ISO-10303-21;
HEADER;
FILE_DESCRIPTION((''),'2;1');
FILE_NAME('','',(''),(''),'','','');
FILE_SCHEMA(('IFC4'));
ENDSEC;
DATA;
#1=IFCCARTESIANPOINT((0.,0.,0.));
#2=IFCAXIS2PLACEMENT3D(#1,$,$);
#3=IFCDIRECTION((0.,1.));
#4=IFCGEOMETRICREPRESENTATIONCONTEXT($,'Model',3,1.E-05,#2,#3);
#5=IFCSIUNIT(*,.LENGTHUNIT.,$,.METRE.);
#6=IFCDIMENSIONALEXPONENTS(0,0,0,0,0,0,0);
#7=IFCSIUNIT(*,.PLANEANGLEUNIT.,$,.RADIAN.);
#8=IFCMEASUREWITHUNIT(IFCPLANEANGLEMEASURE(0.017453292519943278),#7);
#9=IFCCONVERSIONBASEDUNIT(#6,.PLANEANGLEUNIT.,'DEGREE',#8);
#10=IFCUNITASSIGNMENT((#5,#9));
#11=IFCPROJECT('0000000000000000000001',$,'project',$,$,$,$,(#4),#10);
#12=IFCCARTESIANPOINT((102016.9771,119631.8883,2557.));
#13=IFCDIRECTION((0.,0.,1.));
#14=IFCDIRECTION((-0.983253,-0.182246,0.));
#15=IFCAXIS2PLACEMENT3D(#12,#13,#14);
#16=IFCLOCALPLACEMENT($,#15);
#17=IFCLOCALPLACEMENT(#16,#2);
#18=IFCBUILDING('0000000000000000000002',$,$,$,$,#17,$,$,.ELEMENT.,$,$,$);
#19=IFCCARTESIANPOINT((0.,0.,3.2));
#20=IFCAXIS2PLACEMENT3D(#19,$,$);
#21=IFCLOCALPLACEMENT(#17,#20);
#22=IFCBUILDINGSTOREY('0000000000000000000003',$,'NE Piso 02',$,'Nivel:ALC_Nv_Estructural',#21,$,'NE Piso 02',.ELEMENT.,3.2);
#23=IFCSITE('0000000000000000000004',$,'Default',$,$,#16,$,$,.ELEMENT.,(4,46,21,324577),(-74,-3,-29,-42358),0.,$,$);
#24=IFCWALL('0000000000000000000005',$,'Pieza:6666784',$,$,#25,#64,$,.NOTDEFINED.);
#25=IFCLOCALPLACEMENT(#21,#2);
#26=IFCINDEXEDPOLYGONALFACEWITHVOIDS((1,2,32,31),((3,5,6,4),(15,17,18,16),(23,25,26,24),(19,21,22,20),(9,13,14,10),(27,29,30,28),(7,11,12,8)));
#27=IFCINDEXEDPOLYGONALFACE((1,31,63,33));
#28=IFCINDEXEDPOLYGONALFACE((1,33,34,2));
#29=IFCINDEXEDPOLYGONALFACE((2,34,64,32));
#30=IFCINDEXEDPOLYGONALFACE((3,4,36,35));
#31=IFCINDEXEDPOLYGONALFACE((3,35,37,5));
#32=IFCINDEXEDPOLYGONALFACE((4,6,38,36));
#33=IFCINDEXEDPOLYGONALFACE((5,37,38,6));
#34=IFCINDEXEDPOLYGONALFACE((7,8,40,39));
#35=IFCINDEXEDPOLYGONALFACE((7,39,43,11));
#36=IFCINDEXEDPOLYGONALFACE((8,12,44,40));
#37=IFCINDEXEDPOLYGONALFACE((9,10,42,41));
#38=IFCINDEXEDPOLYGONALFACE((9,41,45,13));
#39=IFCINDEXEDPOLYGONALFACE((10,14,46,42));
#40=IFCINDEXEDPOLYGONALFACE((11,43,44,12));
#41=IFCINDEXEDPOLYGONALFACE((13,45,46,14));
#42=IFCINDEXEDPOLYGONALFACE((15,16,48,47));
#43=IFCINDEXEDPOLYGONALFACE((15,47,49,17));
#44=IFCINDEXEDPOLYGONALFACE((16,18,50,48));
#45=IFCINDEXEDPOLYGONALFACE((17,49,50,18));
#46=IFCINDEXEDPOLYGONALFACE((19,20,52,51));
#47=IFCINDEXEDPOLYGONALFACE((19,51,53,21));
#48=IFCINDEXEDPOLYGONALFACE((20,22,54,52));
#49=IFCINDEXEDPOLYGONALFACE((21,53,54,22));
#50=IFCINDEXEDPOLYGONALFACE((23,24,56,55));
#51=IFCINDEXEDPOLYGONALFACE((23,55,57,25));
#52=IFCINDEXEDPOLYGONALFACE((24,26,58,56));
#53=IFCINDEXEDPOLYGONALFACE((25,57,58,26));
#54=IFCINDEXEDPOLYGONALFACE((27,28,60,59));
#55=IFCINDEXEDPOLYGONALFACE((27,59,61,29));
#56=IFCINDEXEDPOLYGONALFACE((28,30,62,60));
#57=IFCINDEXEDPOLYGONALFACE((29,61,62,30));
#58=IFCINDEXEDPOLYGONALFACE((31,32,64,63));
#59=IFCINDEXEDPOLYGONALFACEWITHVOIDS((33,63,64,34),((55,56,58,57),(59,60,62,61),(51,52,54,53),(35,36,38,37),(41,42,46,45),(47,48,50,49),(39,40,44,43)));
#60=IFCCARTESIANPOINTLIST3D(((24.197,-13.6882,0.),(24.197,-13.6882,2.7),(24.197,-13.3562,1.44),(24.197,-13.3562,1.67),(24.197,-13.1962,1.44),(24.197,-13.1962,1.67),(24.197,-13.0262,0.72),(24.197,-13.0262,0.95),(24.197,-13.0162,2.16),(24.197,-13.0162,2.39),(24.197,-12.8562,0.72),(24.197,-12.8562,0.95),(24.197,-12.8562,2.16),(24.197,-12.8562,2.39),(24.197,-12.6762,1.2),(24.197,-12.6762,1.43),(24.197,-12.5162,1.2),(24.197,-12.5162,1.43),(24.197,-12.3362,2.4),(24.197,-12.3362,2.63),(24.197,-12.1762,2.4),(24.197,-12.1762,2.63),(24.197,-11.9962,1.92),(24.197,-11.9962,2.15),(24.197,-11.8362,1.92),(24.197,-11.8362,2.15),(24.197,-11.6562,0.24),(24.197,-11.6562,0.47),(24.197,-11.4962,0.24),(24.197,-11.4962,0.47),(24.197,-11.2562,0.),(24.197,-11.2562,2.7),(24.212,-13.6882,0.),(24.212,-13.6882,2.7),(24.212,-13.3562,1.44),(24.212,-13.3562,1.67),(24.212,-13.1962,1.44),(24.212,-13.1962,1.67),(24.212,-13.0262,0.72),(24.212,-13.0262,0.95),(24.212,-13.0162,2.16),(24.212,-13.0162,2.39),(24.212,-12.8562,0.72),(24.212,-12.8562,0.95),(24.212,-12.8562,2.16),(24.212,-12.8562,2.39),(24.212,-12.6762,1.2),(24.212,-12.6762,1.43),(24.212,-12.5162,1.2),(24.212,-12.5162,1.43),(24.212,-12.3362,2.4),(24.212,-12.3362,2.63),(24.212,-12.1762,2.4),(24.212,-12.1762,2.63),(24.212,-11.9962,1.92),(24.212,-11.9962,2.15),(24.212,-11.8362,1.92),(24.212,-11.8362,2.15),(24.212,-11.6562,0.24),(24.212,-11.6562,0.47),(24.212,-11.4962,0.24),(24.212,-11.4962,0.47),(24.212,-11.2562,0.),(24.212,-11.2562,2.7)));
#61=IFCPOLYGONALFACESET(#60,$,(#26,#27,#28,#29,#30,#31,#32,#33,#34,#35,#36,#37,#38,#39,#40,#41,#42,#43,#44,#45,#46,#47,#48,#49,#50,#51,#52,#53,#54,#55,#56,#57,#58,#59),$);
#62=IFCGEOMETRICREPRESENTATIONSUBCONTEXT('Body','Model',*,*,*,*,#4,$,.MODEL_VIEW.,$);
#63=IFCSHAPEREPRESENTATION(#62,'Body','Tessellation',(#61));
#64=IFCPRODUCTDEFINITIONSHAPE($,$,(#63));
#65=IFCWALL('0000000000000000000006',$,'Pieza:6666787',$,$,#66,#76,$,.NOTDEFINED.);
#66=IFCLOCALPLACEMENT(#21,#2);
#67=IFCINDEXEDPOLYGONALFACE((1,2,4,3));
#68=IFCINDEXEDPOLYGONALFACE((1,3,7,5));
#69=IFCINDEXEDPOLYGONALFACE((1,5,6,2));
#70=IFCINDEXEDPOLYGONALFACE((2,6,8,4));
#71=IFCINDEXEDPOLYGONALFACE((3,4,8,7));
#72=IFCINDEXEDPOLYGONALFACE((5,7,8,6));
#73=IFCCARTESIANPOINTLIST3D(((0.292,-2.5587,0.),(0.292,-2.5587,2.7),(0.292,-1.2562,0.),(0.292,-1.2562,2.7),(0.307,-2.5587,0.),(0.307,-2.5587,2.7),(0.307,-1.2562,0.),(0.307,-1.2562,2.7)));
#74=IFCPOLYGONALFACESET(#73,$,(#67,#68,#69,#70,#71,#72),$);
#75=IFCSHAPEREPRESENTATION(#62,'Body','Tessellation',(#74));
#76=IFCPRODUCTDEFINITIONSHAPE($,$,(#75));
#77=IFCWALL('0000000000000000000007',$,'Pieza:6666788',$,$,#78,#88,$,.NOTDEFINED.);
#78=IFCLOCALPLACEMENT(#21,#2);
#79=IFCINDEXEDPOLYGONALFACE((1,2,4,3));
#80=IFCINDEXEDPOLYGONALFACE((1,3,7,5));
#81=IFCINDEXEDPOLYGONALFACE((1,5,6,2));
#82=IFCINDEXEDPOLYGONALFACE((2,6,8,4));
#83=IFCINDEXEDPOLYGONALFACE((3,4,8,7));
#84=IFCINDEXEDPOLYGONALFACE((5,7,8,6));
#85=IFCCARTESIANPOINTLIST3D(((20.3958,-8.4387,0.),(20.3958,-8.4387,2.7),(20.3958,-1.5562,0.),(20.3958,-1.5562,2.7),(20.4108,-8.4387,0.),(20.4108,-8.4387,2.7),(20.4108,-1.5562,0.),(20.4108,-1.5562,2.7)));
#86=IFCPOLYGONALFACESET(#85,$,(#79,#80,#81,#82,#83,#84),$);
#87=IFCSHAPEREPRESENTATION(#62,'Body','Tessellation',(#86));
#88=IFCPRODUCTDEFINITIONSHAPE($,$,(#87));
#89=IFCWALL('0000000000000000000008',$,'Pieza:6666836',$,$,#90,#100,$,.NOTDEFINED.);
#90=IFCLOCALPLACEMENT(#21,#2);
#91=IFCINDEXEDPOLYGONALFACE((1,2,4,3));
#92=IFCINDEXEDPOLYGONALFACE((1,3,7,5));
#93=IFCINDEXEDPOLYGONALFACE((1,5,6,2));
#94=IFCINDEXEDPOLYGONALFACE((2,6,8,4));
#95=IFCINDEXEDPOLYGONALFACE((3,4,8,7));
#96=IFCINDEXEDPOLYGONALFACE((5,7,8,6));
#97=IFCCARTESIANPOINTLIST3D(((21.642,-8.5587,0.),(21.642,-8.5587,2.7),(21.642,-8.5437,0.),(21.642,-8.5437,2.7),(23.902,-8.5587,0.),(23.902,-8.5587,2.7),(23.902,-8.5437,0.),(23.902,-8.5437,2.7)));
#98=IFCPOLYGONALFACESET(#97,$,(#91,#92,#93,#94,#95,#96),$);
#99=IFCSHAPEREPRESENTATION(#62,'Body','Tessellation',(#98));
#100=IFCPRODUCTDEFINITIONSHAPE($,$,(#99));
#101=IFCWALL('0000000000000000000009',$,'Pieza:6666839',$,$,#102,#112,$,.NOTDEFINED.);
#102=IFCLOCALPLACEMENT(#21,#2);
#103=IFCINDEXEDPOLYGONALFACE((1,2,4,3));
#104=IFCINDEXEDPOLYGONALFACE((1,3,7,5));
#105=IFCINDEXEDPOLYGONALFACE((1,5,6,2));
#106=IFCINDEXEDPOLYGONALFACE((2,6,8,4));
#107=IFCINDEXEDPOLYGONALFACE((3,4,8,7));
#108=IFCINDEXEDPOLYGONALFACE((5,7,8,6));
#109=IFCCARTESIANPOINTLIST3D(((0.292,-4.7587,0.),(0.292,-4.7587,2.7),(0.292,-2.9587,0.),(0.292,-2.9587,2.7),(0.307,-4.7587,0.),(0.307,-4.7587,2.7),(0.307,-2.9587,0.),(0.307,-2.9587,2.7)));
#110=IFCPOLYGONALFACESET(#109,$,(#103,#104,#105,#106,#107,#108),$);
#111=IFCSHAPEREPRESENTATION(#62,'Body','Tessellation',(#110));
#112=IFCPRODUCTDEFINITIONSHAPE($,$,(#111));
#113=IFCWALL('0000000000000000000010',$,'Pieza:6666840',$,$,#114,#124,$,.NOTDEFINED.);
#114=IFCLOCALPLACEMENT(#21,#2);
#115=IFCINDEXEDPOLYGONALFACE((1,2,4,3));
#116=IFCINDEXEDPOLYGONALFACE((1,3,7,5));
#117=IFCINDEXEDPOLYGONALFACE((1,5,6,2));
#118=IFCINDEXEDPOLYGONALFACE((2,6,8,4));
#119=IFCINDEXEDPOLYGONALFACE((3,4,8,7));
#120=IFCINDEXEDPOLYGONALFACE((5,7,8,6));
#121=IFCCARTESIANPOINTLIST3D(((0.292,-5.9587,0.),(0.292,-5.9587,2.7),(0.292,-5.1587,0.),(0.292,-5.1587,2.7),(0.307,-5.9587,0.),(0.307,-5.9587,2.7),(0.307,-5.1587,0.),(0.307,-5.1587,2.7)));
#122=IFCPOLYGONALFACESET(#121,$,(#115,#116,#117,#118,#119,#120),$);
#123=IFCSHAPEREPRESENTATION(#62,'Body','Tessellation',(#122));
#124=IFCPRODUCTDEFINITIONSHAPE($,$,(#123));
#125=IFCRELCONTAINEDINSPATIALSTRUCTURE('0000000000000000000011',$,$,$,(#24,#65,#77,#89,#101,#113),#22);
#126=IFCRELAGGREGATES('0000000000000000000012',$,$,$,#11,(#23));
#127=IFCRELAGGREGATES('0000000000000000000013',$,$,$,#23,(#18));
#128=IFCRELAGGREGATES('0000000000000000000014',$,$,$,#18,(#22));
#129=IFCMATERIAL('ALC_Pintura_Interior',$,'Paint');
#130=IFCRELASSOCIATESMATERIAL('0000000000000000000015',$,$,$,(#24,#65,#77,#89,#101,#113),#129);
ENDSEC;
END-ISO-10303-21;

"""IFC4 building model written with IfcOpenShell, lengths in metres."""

from ifc_helpers import new_model, entity, si_unit, converted_unit, direction, frame, frame_2d, origin, place, context, subcontext, project, spatial, rectangle, extrude, boolean, material, element, save


model = new_model("IFC4")

# Units and contexts
model_context = context("Model", 3, precision=1e-05, world=origin(), true_north=direction((0.0, 1.0)))
body_context = subcontext(model_context, "Body", "Model", "MODEL_VIEW")
ifc_project = project(units=[si_unit("LENGTHUNIT", "METRE"), converted_unit("PLANEANGLEUNIT", "DEGREE", entity("IfcPlaneAngleMeasure", 0.017453292519943278), si_unit("PLANEANGLEUNIT", "RADIAN"), dimensions=[0, 0, 0, 0, 0, 0, 0])], contexts=[model_context])

# Site, building, storey
site_placement = place(None, frame((102016.9771, 119631.8883, 2557.0), z_axis=(0.0, 0.0, 1.0), x_axis=(-0.983253, -0.182246, 0.0)))
site = spatial("IfcSite", under=ifc_project, at=site_placement, Name="Default", CompositionType="ELEMENT", RefLatitude=(4, 46, 21, 324577), RefLongitude=(-74, -3, -29, -42358), RefElevation=0.0)
building_placement = place(site_placement, origin())
building = spatial("IfcBuilding", under=site, at=building_placement, CompositionType="ELEMENT")
storey_placement = place(building_placement, frame((0.0, 0.0, 3.2)))
storey = spatial("IfcBuildingStorey", under=building, at=storey_placement, Name="NE Piso 02", ObjectType="Nivel:ALC_Nv_Estructural", LongName="NE Piso 02", CompositionType="ELEMENT", Elevation=3.2)

# Walls
ifc_material_1 = material(Name="ALC_Pintura_Interior", Category="Paint")
wall_1_placement = place(storey_placement, origin())
element("IfcWall", 1, at=wall_1_placement, inside=storey, material=ifc_material_1, Name="Pieza:6666784", PredefinedType="NOTDEFINED", context=body_context, shape_type="SweptSolid", body=[
    boolean("DIFFERENCE", boolean("DIFFERENCE", boolean("DIFFERENCE", boolean("DIFFERENCE", boolean("DIFFERENCE", boolean("DIFFERENCE", boolean("DIFFERENCE", extrude(rectangle(XDim=0.015, YDim=2.432, at=frame_2d((0.0, 0.0), x_axis=(1.0, 0.0))), frame((24.2045, -12.4722, 0.0)), (0.0, 0.0, 1.0), 2.7), extrude(rectangle(XDim=0.23, YDim=0.16, at=frame_2d((0.0, 0.0), x_axis=(0.0, 1.0))), frame((24.212, -11.5762, 0.355), z_axis=(1.0, 0.0, 0.0), x_axis=(0.0, -1.0, 0.0)), (0.0, 0.0, -1.0), 0.015)), extrude(rectangle(XDim=0.23, YDim=0.17, at=frame_2d((0.0, 0.0), x_axis=(0.0, 1.0))), frame((24.212, -12.9412, 0.835), z_axis=(1.0, 0.0, 0.0), x_axis=(0.0, -1.0, 0.0)), (0.0, 0.0, -1.0), 0.015)), extrude(rectangle(XDim=0.23, YDim=0.16, at=frame_2d((0.0, 0.0), x_axis=(0.0, 1.0))), frame((24.197, -12.5962, 1.315), z_axis=(-1.0, 0.0, 0.0), x_axis=(0.0, 1.0, 0.0)), (0.0, 0.0, -1.0), 0.015)), extrude(rectangle(XDim=0.23, YDim=0.16, at=frame_2d((0.0, 0.0), x_axis=(0.0, 1.0))), frame((24.212, -13.2762, 1.555), z_axis=(1.0, 0.0, 0.0), x_axis=(0.0, -1.0, 0.0)), (0.0, 0.0, -1.0), 0.015)), extrude(rectangle(XDim=0.23, YDim=0.16, at=frame_2d((0.0, 0.0), x_axis=(0.0, 1.0))), frame((24.212, -11.9162, 2.035), z_axis=(1.0, 0.0, 0.0), x_axis=(0.0, -1.0, 0.0)), (0.0, 0.0, -1.0), 0.015)), extrude(rectangle(XDim=0.23, YDim=0.16, at=frame_2d((0.0, 0.0), x_axis=(0.0, 1.0))), frame((24.212, -12.9362, 2.275), z_axis=(1.0, 0.0, 0.0), x_axis=(0.0, -1.0, 0.0)), (0.0, 0.0, -1.0), 0.015)), extrude(rectangle(XDim=0.23, YDim=0.16, at=frame_2d((0.0, 0.0), x_axis=(0.0, 1.0))), frame((24.212, -12.2562, 2.515), z_axis=(1.0, 0.0, 0.0), x_axis=(0.0, -1.0, 0.0)), (0.0, 0.0, -1.0), 0.015)),
])
wall_2_placement = place(storey_placement, origin())
element("IfcWall", 2, at=wall_2_placement, inside=storey, material=ifc_material_1, Name="Pieza:6666787", PredefinedType="NOTDEFINED", context=body_context, shape_type="SweptSolid", body=[
    extrude(rectangle(XDim=1.3025, YDim=0.015, at=frame_2d((0.0, 0.0), x_axis=(1.0, 0.0))), frame((0.2995, -1.9074, 0.0), z_axis=(0.0, 0.0, 1.0), x_axis=(0.0, -1.0, 0.0)), (0.0, 0.0, 1.0), 2.7),
])
wall_3_placement = place(storey_placement, origin())
element("IfcWall", 3, at=wall_3_placement, inside=storey, material=ifc_material_1, Name="Pieza:6666788", PredefinedType="NOTDEFINED", context=body_context, shape_type="SweptSolid", body=[
    extrude(rectangle(XDim=6.8825, YDim=0.015, at=frame_2d((0.0, 0.0), x_axis=(1.0, 0.0))), frame((20.4033, -4.9974, 0.0), z_axis=(0.0, 0.0, 1.0), x_axis=(0.0, -1.0, 0.0)), (0.0, 0.0, 1.0), 2.7),
])
wall_4_placement = place(storey_placement, origin())
element("IfcWall", 4, at=wall_4_placement, inside=storey, material=ifc_material_1, Name="Pieza:6666836", PredefinedType="NOTDEFINED", context=body_context, shape_type="SweptSolid", body=[
    extrude(rectangle(XDim=0.015, YDim=2.26, at=frame_2d((0.0, 0.0), x_axis=(1.0, 0.0))), frame((22.772, -8.5512, 0.0), z_axis=(0.0, 0.0, 1.0), x_axis=(0.0, -1.0, 0.0)), (0.0, 0.0, 1.0), 2.7),
])
wall_5_placement = place(storey_placement, origin())
element("IfcWall", 5, at=wall_5_placement, inside=storey, material=ifc_material_1, Name="Pieza:6666839", PredefinedType="NOTDEFINED", context=body_context, shape_type="SweptSolid", body=[
    extrude(rectangle(XDim=1.8, YDim=0.015, at=frame_2d((0.0, 0.0), x_axis=(1.0, 0.0))), frame((0.2995, -3.8587, 0.0), z_axis=(0.0, 0.0, 1.0), x_axis=(0.0, -1.0, 0.0)), (0.0, 0.0, 1.0), 2.7),
])
wall_6_placement = place(storey_placement, origin())
element("IfcWall", 6, at=wall_6_placement, inside=storey, material=ifc_material_1, Name="Pieza:6666840", PredefinedType="NOTDEFINED", context=body_context, shape_type="SweptSolid", body=[
    extrude(rectangle(XDim=0.8, YDim=0.015, at=frame_2d((0.0, 0.0), x_axis=(1.0, 0.0))), frame((0.2995, -5.5587, 0.0), z_axis=(0.0, 0.0, 1.0), x_axis=(0.0, -1.0, 0.0)), (0.0, 0.0, 1.0), 2.7),
])

save(model, "model.ifc")
